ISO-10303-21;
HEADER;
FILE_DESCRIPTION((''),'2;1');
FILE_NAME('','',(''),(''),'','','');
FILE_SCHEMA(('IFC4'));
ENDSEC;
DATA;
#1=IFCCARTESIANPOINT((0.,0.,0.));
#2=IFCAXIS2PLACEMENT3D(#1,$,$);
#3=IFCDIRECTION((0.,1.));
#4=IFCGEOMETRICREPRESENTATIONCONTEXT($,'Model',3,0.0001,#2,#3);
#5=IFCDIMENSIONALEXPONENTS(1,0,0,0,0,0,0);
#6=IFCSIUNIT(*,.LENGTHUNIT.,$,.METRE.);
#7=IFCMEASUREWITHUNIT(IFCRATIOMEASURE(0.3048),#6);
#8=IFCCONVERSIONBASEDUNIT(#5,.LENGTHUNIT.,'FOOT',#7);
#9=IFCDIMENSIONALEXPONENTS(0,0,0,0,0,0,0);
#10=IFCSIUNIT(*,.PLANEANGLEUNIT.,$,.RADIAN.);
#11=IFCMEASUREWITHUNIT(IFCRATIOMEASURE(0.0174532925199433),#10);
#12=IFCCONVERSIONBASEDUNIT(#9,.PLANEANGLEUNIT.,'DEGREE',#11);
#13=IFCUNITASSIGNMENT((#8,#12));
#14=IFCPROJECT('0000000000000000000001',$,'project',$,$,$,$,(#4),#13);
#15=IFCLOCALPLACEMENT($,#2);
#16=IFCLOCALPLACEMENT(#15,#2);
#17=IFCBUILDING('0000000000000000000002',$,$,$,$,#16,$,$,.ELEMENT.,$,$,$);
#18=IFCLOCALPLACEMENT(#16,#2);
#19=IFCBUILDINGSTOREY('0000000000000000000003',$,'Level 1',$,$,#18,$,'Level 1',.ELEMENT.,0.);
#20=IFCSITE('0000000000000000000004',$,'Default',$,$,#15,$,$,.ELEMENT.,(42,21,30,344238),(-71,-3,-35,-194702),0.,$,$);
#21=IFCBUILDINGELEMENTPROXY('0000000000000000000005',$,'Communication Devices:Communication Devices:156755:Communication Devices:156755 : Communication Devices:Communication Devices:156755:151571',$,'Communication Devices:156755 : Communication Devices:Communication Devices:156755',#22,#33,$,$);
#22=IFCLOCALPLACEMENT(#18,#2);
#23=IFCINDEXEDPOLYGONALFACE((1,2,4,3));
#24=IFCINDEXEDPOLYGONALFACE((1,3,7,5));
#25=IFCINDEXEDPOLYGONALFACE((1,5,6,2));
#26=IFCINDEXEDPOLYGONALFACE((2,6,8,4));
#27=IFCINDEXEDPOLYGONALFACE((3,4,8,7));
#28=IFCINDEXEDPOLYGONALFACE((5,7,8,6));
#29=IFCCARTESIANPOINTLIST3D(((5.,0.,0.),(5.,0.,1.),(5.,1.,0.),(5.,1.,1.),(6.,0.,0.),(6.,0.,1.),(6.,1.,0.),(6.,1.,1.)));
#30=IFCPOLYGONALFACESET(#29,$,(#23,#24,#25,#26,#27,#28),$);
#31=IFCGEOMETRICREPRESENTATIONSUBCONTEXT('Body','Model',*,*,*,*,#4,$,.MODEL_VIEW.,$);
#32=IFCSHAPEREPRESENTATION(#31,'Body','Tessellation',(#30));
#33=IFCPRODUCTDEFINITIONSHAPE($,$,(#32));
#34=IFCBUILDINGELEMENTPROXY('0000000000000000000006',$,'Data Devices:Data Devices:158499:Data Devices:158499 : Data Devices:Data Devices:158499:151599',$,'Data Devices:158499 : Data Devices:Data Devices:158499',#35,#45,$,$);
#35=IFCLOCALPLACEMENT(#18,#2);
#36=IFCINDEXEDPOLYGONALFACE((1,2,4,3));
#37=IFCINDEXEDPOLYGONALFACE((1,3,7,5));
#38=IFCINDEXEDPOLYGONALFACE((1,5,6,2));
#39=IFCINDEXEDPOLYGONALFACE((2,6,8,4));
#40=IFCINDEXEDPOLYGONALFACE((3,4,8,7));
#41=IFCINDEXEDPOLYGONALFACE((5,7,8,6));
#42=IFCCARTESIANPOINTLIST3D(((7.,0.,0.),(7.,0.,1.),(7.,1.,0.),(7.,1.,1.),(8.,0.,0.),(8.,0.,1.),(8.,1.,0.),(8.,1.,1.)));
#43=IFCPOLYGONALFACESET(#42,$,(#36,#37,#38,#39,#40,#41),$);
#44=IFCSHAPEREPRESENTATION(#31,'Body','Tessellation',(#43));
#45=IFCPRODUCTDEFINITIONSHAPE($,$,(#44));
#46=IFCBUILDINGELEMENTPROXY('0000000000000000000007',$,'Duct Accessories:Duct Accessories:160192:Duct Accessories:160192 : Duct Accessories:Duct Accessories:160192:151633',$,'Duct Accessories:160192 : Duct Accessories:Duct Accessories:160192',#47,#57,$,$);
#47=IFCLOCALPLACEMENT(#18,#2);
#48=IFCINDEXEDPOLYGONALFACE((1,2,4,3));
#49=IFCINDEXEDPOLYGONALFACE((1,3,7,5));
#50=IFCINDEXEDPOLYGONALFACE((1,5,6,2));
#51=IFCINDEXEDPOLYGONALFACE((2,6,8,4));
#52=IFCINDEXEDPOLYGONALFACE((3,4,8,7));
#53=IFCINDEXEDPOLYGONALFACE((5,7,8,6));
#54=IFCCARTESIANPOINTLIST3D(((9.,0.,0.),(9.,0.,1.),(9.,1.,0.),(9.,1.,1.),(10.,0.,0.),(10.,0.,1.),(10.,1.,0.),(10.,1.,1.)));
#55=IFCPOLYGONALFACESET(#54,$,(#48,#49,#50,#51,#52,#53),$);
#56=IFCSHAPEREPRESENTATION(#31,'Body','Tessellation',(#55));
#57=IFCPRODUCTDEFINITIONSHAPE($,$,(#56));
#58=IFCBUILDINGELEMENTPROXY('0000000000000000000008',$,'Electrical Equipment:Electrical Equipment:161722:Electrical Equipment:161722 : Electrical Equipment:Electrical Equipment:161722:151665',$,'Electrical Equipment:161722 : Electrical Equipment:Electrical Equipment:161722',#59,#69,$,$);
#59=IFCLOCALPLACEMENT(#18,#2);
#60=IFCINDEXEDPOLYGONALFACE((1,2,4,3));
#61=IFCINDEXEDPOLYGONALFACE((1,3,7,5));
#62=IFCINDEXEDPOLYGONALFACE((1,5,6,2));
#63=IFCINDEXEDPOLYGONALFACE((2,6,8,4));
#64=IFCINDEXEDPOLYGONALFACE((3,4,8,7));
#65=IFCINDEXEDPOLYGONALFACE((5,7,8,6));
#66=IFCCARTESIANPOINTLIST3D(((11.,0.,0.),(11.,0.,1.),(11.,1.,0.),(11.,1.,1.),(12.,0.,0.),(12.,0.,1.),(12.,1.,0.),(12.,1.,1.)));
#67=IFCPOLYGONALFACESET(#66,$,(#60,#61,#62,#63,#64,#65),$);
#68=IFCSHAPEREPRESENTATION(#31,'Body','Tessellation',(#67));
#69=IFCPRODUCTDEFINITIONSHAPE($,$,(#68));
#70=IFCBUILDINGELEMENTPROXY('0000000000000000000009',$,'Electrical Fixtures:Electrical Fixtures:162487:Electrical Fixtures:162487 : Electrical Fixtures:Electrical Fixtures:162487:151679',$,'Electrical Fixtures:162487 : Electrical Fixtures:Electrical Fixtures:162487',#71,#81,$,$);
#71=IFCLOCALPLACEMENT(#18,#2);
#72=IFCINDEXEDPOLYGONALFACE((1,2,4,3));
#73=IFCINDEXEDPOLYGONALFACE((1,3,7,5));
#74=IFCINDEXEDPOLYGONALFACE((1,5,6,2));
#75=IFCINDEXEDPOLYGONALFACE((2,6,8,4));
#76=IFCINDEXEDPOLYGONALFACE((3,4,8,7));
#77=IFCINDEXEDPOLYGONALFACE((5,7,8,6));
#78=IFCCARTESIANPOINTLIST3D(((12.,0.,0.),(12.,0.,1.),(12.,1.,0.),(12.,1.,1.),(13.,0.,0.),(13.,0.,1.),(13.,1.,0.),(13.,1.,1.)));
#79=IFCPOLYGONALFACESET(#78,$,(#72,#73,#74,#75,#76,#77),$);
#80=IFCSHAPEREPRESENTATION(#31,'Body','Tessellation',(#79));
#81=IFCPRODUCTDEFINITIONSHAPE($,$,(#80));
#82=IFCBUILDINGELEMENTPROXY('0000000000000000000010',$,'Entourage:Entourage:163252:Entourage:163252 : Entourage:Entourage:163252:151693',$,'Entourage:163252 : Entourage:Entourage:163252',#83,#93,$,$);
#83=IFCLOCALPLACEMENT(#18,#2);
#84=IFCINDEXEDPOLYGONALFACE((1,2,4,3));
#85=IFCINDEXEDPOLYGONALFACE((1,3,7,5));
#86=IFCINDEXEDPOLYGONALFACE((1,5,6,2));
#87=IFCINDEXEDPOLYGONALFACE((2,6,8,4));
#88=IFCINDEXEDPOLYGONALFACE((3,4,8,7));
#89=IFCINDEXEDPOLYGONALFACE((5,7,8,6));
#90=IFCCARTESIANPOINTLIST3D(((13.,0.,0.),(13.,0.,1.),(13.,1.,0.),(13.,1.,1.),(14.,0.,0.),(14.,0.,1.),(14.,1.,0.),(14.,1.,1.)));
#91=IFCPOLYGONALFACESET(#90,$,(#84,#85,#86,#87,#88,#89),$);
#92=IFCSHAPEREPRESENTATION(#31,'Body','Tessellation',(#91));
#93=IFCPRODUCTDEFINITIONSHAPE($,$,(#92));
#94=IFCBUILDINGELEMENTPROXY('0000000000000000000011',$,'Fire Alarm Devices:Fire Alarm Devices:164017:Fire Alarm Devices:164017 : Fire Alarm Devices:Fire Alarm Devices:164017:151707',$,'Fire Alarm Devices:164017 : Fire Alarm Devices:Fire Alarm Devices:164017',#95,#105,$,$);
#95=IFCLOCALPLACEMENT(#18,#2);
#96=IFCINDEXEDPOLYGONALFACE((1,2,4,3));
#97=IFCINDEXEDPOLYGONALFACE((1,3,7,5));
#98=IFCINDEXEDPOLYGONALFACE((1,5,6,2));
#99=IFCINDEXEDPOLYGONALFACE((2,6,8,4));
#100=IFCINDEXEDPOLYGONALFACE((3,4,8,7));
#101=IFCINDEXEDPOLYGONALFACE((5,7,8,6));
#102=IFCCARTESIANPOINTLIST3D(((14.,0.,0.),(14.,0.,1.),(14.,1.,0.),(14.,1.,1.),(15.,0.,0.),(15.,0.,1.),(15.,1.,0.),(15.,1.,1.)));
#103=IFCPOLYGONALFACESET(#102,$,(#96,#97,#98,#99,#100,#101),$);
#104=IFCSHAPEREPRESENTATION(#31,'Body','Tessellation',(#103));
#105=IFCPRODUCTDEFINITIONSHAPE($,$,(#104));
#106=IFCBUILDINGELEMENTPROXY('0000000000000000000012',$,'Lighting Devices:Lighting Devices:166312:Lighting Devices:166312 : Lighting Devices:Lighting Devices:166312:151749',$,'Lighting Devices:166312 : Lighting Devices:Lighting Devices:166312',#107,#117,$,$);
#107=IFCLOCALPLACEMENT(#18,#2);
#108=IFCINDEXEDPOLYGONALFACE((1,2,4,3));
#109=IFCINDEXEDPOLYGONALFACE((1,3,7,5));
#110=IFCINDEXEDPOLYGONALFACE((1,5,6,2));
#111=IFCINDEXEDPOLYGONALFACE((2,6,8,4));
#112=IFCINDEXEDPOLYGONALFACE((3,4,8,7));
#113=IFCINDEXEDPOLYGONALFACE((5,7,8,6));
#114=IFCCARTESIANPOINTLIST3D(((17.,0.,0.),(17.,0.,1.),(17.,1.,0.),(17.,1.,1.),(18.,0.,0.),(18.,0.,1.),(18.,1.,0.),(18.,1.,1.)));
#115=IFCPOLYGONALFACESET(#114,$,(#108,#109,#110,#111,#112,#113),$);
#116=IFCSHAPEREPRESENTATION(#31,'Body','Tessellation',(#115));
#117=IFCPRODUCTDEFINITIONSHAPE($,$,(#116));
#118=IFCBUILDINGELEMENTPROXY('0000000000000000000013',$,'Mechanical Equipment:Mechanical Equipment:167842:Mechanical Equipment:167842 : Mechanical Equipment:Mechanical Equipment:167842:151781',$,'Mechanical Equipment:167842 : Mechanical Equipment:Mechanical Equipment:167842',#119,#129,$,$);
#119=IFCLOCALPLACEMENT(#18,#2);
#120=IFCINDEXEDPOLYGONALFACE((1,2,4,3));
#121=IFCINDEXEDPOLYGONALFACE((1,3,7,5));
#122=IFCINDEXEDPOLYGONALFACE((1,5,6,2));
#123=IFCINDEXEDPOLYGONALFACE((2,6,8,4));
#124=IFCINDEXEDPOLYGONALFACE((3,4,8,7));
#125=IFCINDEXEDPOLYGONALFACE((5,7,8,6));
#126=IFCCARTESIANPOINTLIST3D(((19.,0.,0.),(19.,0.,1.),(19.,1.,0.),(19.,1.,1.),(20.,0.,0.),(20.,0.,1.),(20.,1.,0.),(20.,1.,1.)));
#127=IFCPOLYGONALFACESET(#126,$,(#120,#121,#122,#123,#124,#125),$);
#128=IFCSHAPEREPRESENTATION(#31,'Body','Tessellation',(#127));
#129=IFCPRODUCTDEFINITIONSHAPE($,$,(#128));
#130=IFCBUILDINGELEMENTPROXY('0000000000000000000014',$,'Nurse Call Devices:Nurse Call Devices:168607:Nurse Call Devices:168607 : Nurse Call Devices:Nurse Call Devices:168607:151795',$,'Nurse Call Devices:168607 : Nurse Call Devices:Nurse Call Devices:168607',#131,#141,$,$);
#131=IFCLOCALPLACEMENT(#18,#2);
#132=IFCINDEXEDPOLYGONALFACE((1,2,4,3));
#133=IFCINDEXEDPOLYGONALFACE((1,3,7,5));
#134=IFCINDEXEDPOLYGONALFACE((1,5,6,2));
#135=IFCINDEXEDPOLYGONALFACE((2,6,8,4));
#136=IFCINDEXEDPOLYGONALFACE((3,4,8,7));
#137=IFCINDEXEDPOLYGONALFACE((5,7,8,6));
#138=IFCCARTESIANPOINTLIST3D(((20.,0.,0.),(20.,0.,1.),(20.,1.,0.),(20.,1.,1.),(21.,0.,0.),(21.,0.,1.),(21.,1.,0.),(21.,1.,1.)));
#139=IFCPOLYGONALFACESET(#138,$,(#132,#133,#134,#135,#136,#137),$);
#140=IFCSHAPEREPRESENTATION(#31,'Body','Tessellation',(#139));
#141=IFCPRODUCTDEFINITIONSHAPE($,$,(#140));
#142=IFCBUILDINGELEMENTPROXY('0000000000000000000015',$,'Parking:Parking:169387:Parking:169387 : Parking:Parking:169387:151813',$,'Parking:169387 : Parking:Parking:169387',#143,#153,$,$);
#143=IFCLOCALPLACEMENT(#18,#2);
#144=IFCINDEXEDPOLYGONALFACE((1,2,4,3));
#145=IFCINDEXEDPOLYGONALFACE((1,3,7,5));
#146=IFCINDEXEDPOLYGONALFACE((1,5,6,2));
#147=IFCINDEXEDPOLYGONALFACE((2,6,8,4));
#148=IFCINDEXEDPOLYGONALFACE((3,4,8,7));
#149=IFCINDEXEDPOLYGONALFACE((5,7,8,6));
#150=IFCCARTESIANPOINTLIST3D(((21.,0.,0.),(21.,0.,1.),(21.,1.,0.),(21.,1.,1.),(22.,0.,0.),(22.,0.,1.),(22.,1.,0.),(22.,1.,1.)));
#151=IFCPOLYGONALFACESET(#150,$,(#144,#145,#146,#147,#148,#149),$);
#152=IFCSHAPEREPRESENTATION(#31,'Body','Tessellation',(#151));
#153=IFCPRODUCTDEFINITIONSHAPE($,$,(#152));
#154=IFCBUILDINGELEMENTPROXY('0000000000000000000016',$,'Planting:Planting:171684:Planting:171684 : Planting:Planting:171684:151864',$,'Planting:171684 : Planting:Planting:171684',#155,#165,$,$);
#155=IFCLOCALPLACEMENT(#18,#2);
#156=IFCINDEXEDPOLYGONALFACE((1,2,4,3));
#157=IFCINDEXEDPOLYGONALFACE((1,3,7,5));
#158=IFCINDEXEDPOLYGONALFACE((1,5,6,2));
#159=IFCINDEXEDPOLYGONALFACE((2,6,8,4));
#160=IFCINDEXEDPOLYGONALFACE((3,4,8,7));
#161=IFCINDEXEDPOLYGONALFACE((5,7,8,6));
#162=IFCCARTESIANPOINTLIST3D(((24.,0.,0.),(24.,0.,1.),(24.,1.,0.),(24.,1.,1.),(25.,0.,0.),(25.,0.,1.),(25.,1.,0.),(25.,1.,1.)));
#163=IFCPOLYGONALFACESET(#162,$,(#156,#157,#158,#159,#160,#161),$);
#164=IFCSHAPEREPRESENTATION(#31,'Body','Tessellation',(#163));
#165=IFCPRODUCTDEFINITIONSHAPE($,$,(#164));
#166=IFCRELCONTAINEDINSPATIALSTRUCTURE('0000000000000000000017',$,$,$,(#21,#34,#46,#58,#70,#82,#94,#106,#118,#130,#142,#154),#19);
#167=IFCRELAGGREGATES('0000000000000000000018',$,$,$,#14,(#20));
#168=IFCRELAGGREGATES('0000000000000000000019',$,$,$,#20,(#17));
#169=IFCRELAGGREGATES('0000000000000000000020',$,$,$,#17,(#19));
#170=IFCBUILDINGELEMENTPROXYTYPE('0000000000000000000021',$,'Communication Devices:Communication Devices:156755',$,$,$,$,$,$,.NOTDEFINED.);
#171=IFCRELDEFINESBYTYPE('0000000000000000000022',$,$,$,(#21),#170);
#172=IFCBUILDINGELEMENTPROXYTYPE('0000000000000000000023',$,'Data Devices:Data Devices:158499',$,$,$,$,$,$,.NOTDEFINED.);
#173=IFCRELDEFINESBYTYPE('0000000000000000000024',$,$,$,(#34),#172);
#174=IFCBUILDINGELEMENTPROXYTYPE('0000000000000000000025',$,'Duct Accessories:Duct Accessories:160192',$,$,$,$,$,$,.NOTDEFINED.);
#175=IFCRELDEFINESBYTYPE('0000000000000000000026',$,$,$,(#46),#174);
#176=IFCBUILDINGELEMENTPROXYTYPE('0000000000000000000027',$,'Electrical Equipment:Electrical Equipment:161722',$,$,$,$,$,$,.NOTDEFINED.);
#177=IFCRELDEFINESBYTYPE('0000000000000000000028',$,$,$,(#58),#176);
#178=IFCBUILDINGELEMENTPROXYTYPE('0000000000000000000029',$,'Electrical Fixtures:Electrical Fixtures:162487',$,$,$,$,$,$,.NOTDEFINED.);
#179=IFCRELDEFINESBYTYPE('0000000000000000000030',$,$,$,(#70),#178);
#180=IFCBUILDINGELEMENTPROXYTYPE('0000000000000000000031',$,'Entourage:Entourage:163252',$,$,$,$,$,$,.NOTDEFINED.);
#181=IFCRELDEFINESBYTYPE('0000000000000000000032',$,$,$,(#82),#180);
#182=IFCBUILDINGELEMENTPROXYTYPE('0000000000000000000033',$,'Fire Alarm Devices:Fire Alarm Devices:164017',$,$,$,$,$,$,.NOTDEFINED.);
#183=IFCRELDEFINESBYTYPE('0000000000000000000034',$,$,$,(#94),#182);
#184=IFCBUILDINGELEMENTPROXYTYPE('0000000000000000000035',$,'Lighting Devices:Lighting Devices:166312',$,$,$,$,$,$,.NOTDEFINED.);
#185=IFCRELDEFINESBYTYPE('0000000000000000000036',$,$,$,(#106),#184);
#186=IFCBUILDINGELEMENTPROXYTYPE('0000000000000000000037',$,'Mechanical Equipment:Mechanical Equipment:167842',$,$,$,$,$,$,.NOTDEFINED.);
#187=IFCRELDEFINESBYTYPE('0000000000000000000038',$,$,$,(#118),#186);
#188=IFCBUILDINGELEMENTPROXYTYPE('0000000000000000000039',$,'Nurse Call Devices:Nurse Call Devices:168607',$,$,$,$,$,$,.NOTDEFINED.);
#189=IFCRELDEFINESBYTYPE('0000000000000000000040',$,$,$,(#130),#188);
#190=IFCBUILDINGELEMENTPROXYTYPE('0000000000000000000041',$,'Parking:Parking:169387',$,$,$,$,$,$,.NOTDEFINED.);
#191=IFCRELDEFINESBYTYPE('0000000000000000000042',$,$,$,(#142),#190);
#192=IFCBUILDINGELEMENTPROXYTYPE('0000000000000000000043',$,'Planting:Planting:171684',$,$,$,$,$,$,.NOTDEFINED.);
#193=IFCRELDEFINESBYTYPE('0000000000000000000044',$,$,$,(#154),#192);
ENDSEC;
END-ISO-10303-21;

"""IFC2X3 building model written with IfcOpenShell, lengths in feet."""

from ifc_helpers import new_model, entity, si_unit, converted_unit, direction, frame, frame_2d, origin, origin_2d_with_axis, place, context, subcontext, project, spatial, rectangle, extrude, source, transform, mapped, type_object, type_shapes, element, save


model = new_model("IFC2X3")

# Units and contexts
model_context = context("Model", 3, precision=0.0001, world=origin(), true_north=direction((0.0, 1.0)))
body_context = subcontext(model_context, "Body", "Model", "MODEL_VIEW")
ifc_project = project(units=[converted_unit("LENGTHUNIT", "FOOT", entity("IfcRatioMeasure", 0.3048), si_unit("LENGTHUNIT", "METRE"), dimensions=[1, 0, 0, 0, 0, 0, 0]), converted_unit("PLANEANGLEUNIT", "DEGREE", entity("IfcRatioMeasure", 0.0174532925199433), si_unit("PLANEANGLEUNIT", "RADIAN"), dimensions=[0, 0, 0, 0, 0, 0, 0])], contexts=[model_context])

# Site, building, storey
site_placement = place(None, origin())
site = spatial("IfcSite", under=ifc_project, at=site_placement, Name="Default", CompositionType="ELEMENT", RefLatitude=(42, 21, 30, 344238), RefLongitude=(-71, -3, -35, -194702), RefElevation=0.0)
building_placement = place(site_placement, origin())
building = spatial("IfcBuilding", under=site, at=building_placement, CompositionType="ELEMENT")
storey_placement = place(building_placement, origin())
storey = spatial("IfcBuildingStorey", under=building, at=storey_placement, Name="Level 1", LongName="Level 1", CompositionType="ELEMENT", Elevation=0.0)

# Building element proxies
building_element_proxy_type_1 = type_object("IfcBuildingElementProxyType", Name="Communication Devices:Communication Devices:156755", PredefinedType="NOTDEFINED")
shared_shape_1 = source(origin(), body_context, "Body", "SweptSolid", [
    extrude(rectangle(XDim=1.0, YDim=1.0, at=frame_2d((0.0, 0.0), x_axis=(1.0, 0.0))), frame((5.5, 0.5, 0.0), z_axis=(0.0, 0.0, 1.0), x_axis=(-1.0, 0.0, 0.0)), (0.0, 0.0, 1.0), 1.0),
])
type_shapes(building_element_proxy_type_1, [shared_shape_1])
proxy_1_placement = place(storey_placement, origin())
element("IfcBuildingElementProxy", 1, at=proxy_1_placement, inside=storey, type_object=building_element_proxy_type_1, Name="Communication Devices:Communication Devices:156755:Communication Devices:156755 : Communication Devices:Communication Devices:156755:151571", ObjectType="Communication Devices:156755 : Communication Devices:Communication Devices:156755", context=body_context, shape_type="MappedRepresentation", body=[
    mapped(shared_shape_1, transform((0.0, 0.0, 0.0), scale=1.0)),
])
building_element_proxy_type_2 = type_object("IfcBuildingElementProxyType", Name="Data Devices:Data Devices:158499", PredefinedType="NOTDEFINED")
shared_shape_2 = source(origin(), body_context, "Body", "SweptSolid", [
    extrude(rectangle(XDim=1.0, YDim=1.0, at=frame_2d((0.0, 0.0), x_axis=(1.0, 0.0))), frame((7.5, 0.5, 0.0), z_axis=(0.0, 0.0, 1.0), x_axis=(-1.0, 0.0, 0.0)), (0.0, 0.0, 1.0), 1.0),
])
type_shapes(building_element_proxy_type_2, [shared_shape_2])
proxy_2_placement = place(storey_placement, origin())
element("IfcBuildingElementProxy", 2, at=proxy_2_placement, inside=storey, type_object=building_element_proxy_type_2, Name="Data Devices:Data Devices:158499:Data Devices:158499 : Data Devices:Data Devices:158499:151599", ObjectType="Data Devices:158499 : Data Devices:Data Devices:158499", context=body_context, shape_type="MappedRepresentation", body=[
    mapped(shared_shape_2, transform((0.0, 0.0, 0.0), scale=1.0)),
])
building_element_proxy_type_3 = type_object("IfcBuildingElementProxyType", Name="Duct Accessories:Duct Accessories:160192", PredefinedType="NOTDEFINED")
shared_shape_3 = source(origin(), body_context, "Body", "SweptSolid", [
    extrude(rectangle(XDim=1.0, YDim=1.0, at=origin_2d_with_axis()), frame((9.5, 0.5, 0.0), z_axis=(0.0, 0.0, 1.0), x_axis=(-1.0, 0.0, 0.0)), (0.0, 0.0, 1.0), 1.0),
])
type_shapes(building_element_proxy_type_3, [shared_shape_3])
proxy_3_placement = place(storey_placement, origin())
element("IfcBuildingElementProxy", 3, at=proxy_3_placement, inside=storey, type_object=building_element_proxy_type_3, Name="Duct Accessories:Duct Accessories:160192:Duct Accessories:160192 : Duct Accessories:Duct Accessories:160192:151633", ObjectType="Duct Accessories:160192 : Duct Accessories:Duct Accessories:160192", context=body_context, shape_type="MappedRepresentation", body=[
    mapped(shared_shape_3, transform((0.0, 0.0, 0.0), scale=1.0)),
])
building_element_proxy_type_4 = type_object("IfcBuildingElementProxyType", Name="Electrical Equipment:Electrical Equipment:161722", PredefinedType="NOTDEFINED")
shared_shape_4 = source(origin(), body_context, "Body", "SweptSolid", [
    extrude(rectangle(XDim=1.0, YDim=1.0, at=origin_2d_with_axis()), frame((11.5, 0.5, 0.0), z_axis=(0.0, 0.0, 1.0), x_axis=(-1.0, 0.0, 0.0)), (0.0, 0.0, 1.0), 1.0),
])
type_shapes(building_element_proxy_type_4, [shared_shape_4])
proxy_4_placement = place(storey_placement, origin())
element("IfcBuildingElementProxy", 4, at=proxy_4_placement, inside=storey, type_object=building_element_proxy_type_4, Name="Electrical Equipment:Electrical Equipment:161722:Electrical Equipment:161722 : Electrical Equipment:Electrical Equipment:161722:151665", ObjectType="Electrical Equipment:161722 : Electrical Equipment:Electrical Equipment:161722", context=body_context, shape_type="MappedRepresentation", body=[
    mapped(shared_shape_4, transform((0.0, 0.0, 0.0), scale=1.0)),
])
building_element_proxy_type_5 = type_object("IfcBuildingElementProxyType", Name="Electrical Fixtures:Electrical Fixtures:162487", PredefinedType="NOTDEFINED")
shared_shape_5 = source(origin(), body_context, "Body", "SweptSolid", [
    extrude(rectangle(XDim=1.0, YDim=1.0, at=origin_2d_with_axis()), frame((12.5, 0.5, 0.0), z_axis=(0.0, 0.0, 1.0), x_axis=(-1.0, 0.0, 0.0)), (0.0, 0.0, 1.0), 1.0),
])
type_shapes(building_element_proxy_type_5, [shared_shape_5])
proxy_5_placement = place(storey_placement, origin())
element("IfcBuildingElementProxy", 5, at=proxy_5_placement, inside=storey, type_object=building_element_proxy_type_5, Name="Electrical Fixtures:Electrical Fixtures:162487:Electrical Fixtures:162487 : Electrical Fixtures:Electrical Fixtures:162487:151679", ObjectType="Electrical Fixtures:162487 : Electrical Fixtures:Electrical Fixtures:162487", context=body_context, shape_type="MappedRepresentation", body=[
    mapped(shared_shape_5, transform((0.0, 0.0, 0.0), scale=1.0)),
])
building_element_proxy_type_6 = type_object("IfcBuildingElementProxyType", Name="Entourage:Entourage:163252", PredefinedType="NOTDEFINED")
shared_shape_6 = source(origin(), body_context, "Body", "SweptSolid", [
    extrude(rectangle(XDim=1.0, YDim=1.0, at=origin_2d_with_axis()), frame((13.5, 0.5, 0.0), z_axis=(0.0, 0.0, 1.0), x_axis=(-1.0, 0.0, 0.0)), (0.0, 0.0, 1.0), 1.0),
])
type_shapes(building_element_proxy_type_6, [shared_shape_6])
proxy_6_placement = place(storey_placement, origin())
element("IfcBuildingElementProxy", 6, at=proxy_6_placement, inside=storey, type_object=building_element_proxy_type_6, Name="Entourage:Entourage:163252:Entourage:163252 : Entourage:Entourage:163252:151693", ObjectType="Entourage:163252 : Entourage:Entourage:163252", context=body_context, shape_type="MappedRepresentation", body=[
    mapped(shared_shape_6, transform((0.0, 0.0, 0.0), scale=1.0)),
])
building_element_proxy_type_7 = type_object("IfcBuildingElementProxyType", Name="Fire Alarm Devices:Fire Alarm Devices:164017", PredefinedType="NOTDEFINED")
shared_shape_7 = source(origin(), body_context, "Body", "SweptSolid", [
    extrude(rectangle(XDim=1.0, YDim=1.0, at=origin_2d_with_axis()), frame((14.5, 0.5, 0.0), z_axis=(0.0, 0.0, 1.0), x_axis=(-1.0, 0.0, 0.0)), (0.0, 0.0, 1.0), 1.0),
])
type_shapes(building_element_proxy_type_7, [shared_shape_7])
proxy_7_placement = place(storey_placement, origin())
element("IfcBuildingElementProxy", 7, at=proxy_7_placement, inside=storey, type_object=building_element_proxy_type_7, Name="Fire Alarm Devices:Fire Alarm Devices:164017:Fire Alarm Devices:164017 : Fire Alarm Devices:Fire Alarm Devices:164017:151707", ObjectType="Fire Alarm Devices:164017 : Fire Alarm Devices:Fire Alarm Devices:164017", context=body_context, shape_type="MappedRepresentation", body=[
    mapped(shared_shape_7, transform((0.0, 0.0, 0.0), scale=1.0)),
])
building_element_proxy_type_8 = type_object("IfcBuildingElementProxyType", Name="Lighting Devices:Lighting Devices:166312", PredefinedType="NOTDEFINED")
shared_shape_8 = source(origin(), body_context, "Body", "SweptSolid", [
    extrude(rectangle(XDim=1.0, YDim=1.0, at=origin_2d_with_axis()), frame((17.5, 0.5, 0.0), z_axis=(0.0, 0.0, 1.0), x_axis=(-1.0, 0.0, 0.0)), (0.0, 0.0, 1.0), 1.0),
])
type_shapes(building_element_proxy_type_8, [shared_shape_8])
proxy_8_placement = place(storey_placement, origin())
element("IfcBuildingElementProxy", 8, at=proxy_8_placement, inside=storey, type_object=building_element_proxy_type_8, Name="Lighting Devices:Lighting Devices:166312:Lighting Devices:166312 : Lighting Devices:Lighting Devices:166312:151749", ObjectType="Lighting Devices:166312 : Lighting Devices:Lighting Devices:166312", context=body_context, shape_type="MappedRepresentation", body=[
    mapped(shared_shape_8, transform((0.0, 0.0, 0.0), scale=1.0)),
])
building_element_proxy_type_9 = type_object("IfcBuildingElementProxyType", Name="Mechanical Equipment:Mechanical Equipment:167842", PredefinedType="NOTDEFINED")
shared_shape_9 = source(origin(), body_context, "Body", "SweptSolid", [
    extrude(rectangle(XDim=1.0, YDim=1.0, at=origin_2d_with_axis()), frame((19.5, 0.5, 0.0), z_axis=(0.0, 0.0, 1.0), x_axis=(-1.0, 0.0, 0.0)), (0.0, 0.0, 1.0), 1.0),
])
type_shapes(building_element_proxy_type_9, [shared_shape_9])
proxy_9_placement = place(storey_placement, origin())
element("IfcBuildingElementProxy", 9, at=proxy_9_placement, inside=storey, type_object=building_element_proxy_type_9, Name="Mechanical Equipment:Mechanical Equipment:167842:Mechanical Equipment:167842 : Mechanical Equipment:Mechanical Equipment:167842:151781", ObjectType="Mechanical Equipment:167842 : Mechanical Equipment:Mechanical Equipment:167842", context=body_context, shape_type="MappedRepresentation", body=[
    mapped(shared_shape_9, transform((0.0, 0.0, 0.0), scale=1.0)),
])
building_element_proxy_type_10 = type_object("IfcBuildingElementProxyType", Name="Nurse Call Devices:Nurse Call Devices:168607", PredefinedType="NOTDEFINED")
shared_shape_10 = source(origin(), body_context, "Body", "SweptSolid", [
    extrude(rectangle(XDim=1.0, YDim=1.0, at=origin_2d_with_axis()), frame((20.5, 0.5, 0.0), z_axis=(0.0, 0.0, 1.0), x_axis=(-1.0, 0.0, 0.0)), (0.0, 0.0, 1.0), 1.0),
])
type_shapes(building_element_proxy_type_10, [shared_shape_10])
proxy_10_placement = place(storey_placement, origin())
element("IfcBuildingElementProxy", 10, at=proxy_10_placement, inside=storey, type_object=building_element_proxy_type_10, Name="Nurse Call Devices:Nurse Call Devices:168607:Nurse Call Devices:168607 : Nurse Call Devices:Nurse Call Devices:168607:151795", ObjectType="Nurse Call Devices:168607 : Nurse Call Devices:Nurse Call Devices:168607", context=body_context, shape_type="MappedRepresentation", body=[
    mapped(shared_shape_10, transform((0.0, 0.0, 0.0), scale=1.0)),
])
building_element_proxy_type_11 = type_object("IfcBuildingElementProxyType", Name="Parking:Parking:169387", PredefinedType="NOTDEFINED")
shared_shape_11 = source(origin(), body_context, "Body", "SweptSolid", [
    extrude(rectangle(XDim=1.0, YDim=1.0, at=origin_2d_with_axis()), frame((21.5, 0.5, 0.0), z_axis=(0.0, 0.0, 1.0), x_axis=(-1.0, 0.0, 0.0)), (0.0, 0.0, 1.0), 1.0),
])
type_shapes(building_element_proxy_type_11, [shared_shape_11])
proxy_11_placement = place(storey_placement, origin())
element("IfcBuildingElementProxy", 11, at=proxy_11_placement, inside=storey, type_object=building_element_proxy_type_11, Name="Parking:Parking:169387:Parking:169387 : Parking:Parking:169387:151813", ObjectType="Parking:169387 : Parking:Parking:169387", context=body_context, shape_type="MappedRepresentation", body=[
    mapped(shared_shape_11, transform((0.0, 0.0, 0.0), scale=1.0)),
])
building_element_proxy_type_12 = type_object("IfcBuildingElementProxyType", Name="Planting:Planting:171684", PredefinedType="NOTDEFINED")
shared_shape_12 = source(origin(), body_context, "Body", "SweptSolid", [
    extrude(rectangle(XDim=1.0, YDim=1.0, at=origin_2d_with_axis()), frame((24.5, 0.5, 0.0), z_axis=(0.0, 0.0, 1.0), x_axis=(-1.0, 0.0, 0.0)), (0.0, 0.0, 1.0), 1.0),
])
type_shapes(building_element_proxy_type_12, [shared_shape_12])
proxy_12_placement = place(storey_placement, origin())
element("IfcBuildingElementProxy", 12, at=proxy_12_placement, inside=storey, type_object=building_element_proxy_type_12, Name="Planting:Planting:171684:Planting:171684 : Planting:Planting:171684:151864", ObjectType="Planting:171684 : Planting:Planting:171684", context=body_context, shape_type="MappedRepresentation", body=[
    mapped(shared_shape_12, transform((0.0, 0.0, 0.0), scale=1.0)),
])

save(model, "model.ifc")
